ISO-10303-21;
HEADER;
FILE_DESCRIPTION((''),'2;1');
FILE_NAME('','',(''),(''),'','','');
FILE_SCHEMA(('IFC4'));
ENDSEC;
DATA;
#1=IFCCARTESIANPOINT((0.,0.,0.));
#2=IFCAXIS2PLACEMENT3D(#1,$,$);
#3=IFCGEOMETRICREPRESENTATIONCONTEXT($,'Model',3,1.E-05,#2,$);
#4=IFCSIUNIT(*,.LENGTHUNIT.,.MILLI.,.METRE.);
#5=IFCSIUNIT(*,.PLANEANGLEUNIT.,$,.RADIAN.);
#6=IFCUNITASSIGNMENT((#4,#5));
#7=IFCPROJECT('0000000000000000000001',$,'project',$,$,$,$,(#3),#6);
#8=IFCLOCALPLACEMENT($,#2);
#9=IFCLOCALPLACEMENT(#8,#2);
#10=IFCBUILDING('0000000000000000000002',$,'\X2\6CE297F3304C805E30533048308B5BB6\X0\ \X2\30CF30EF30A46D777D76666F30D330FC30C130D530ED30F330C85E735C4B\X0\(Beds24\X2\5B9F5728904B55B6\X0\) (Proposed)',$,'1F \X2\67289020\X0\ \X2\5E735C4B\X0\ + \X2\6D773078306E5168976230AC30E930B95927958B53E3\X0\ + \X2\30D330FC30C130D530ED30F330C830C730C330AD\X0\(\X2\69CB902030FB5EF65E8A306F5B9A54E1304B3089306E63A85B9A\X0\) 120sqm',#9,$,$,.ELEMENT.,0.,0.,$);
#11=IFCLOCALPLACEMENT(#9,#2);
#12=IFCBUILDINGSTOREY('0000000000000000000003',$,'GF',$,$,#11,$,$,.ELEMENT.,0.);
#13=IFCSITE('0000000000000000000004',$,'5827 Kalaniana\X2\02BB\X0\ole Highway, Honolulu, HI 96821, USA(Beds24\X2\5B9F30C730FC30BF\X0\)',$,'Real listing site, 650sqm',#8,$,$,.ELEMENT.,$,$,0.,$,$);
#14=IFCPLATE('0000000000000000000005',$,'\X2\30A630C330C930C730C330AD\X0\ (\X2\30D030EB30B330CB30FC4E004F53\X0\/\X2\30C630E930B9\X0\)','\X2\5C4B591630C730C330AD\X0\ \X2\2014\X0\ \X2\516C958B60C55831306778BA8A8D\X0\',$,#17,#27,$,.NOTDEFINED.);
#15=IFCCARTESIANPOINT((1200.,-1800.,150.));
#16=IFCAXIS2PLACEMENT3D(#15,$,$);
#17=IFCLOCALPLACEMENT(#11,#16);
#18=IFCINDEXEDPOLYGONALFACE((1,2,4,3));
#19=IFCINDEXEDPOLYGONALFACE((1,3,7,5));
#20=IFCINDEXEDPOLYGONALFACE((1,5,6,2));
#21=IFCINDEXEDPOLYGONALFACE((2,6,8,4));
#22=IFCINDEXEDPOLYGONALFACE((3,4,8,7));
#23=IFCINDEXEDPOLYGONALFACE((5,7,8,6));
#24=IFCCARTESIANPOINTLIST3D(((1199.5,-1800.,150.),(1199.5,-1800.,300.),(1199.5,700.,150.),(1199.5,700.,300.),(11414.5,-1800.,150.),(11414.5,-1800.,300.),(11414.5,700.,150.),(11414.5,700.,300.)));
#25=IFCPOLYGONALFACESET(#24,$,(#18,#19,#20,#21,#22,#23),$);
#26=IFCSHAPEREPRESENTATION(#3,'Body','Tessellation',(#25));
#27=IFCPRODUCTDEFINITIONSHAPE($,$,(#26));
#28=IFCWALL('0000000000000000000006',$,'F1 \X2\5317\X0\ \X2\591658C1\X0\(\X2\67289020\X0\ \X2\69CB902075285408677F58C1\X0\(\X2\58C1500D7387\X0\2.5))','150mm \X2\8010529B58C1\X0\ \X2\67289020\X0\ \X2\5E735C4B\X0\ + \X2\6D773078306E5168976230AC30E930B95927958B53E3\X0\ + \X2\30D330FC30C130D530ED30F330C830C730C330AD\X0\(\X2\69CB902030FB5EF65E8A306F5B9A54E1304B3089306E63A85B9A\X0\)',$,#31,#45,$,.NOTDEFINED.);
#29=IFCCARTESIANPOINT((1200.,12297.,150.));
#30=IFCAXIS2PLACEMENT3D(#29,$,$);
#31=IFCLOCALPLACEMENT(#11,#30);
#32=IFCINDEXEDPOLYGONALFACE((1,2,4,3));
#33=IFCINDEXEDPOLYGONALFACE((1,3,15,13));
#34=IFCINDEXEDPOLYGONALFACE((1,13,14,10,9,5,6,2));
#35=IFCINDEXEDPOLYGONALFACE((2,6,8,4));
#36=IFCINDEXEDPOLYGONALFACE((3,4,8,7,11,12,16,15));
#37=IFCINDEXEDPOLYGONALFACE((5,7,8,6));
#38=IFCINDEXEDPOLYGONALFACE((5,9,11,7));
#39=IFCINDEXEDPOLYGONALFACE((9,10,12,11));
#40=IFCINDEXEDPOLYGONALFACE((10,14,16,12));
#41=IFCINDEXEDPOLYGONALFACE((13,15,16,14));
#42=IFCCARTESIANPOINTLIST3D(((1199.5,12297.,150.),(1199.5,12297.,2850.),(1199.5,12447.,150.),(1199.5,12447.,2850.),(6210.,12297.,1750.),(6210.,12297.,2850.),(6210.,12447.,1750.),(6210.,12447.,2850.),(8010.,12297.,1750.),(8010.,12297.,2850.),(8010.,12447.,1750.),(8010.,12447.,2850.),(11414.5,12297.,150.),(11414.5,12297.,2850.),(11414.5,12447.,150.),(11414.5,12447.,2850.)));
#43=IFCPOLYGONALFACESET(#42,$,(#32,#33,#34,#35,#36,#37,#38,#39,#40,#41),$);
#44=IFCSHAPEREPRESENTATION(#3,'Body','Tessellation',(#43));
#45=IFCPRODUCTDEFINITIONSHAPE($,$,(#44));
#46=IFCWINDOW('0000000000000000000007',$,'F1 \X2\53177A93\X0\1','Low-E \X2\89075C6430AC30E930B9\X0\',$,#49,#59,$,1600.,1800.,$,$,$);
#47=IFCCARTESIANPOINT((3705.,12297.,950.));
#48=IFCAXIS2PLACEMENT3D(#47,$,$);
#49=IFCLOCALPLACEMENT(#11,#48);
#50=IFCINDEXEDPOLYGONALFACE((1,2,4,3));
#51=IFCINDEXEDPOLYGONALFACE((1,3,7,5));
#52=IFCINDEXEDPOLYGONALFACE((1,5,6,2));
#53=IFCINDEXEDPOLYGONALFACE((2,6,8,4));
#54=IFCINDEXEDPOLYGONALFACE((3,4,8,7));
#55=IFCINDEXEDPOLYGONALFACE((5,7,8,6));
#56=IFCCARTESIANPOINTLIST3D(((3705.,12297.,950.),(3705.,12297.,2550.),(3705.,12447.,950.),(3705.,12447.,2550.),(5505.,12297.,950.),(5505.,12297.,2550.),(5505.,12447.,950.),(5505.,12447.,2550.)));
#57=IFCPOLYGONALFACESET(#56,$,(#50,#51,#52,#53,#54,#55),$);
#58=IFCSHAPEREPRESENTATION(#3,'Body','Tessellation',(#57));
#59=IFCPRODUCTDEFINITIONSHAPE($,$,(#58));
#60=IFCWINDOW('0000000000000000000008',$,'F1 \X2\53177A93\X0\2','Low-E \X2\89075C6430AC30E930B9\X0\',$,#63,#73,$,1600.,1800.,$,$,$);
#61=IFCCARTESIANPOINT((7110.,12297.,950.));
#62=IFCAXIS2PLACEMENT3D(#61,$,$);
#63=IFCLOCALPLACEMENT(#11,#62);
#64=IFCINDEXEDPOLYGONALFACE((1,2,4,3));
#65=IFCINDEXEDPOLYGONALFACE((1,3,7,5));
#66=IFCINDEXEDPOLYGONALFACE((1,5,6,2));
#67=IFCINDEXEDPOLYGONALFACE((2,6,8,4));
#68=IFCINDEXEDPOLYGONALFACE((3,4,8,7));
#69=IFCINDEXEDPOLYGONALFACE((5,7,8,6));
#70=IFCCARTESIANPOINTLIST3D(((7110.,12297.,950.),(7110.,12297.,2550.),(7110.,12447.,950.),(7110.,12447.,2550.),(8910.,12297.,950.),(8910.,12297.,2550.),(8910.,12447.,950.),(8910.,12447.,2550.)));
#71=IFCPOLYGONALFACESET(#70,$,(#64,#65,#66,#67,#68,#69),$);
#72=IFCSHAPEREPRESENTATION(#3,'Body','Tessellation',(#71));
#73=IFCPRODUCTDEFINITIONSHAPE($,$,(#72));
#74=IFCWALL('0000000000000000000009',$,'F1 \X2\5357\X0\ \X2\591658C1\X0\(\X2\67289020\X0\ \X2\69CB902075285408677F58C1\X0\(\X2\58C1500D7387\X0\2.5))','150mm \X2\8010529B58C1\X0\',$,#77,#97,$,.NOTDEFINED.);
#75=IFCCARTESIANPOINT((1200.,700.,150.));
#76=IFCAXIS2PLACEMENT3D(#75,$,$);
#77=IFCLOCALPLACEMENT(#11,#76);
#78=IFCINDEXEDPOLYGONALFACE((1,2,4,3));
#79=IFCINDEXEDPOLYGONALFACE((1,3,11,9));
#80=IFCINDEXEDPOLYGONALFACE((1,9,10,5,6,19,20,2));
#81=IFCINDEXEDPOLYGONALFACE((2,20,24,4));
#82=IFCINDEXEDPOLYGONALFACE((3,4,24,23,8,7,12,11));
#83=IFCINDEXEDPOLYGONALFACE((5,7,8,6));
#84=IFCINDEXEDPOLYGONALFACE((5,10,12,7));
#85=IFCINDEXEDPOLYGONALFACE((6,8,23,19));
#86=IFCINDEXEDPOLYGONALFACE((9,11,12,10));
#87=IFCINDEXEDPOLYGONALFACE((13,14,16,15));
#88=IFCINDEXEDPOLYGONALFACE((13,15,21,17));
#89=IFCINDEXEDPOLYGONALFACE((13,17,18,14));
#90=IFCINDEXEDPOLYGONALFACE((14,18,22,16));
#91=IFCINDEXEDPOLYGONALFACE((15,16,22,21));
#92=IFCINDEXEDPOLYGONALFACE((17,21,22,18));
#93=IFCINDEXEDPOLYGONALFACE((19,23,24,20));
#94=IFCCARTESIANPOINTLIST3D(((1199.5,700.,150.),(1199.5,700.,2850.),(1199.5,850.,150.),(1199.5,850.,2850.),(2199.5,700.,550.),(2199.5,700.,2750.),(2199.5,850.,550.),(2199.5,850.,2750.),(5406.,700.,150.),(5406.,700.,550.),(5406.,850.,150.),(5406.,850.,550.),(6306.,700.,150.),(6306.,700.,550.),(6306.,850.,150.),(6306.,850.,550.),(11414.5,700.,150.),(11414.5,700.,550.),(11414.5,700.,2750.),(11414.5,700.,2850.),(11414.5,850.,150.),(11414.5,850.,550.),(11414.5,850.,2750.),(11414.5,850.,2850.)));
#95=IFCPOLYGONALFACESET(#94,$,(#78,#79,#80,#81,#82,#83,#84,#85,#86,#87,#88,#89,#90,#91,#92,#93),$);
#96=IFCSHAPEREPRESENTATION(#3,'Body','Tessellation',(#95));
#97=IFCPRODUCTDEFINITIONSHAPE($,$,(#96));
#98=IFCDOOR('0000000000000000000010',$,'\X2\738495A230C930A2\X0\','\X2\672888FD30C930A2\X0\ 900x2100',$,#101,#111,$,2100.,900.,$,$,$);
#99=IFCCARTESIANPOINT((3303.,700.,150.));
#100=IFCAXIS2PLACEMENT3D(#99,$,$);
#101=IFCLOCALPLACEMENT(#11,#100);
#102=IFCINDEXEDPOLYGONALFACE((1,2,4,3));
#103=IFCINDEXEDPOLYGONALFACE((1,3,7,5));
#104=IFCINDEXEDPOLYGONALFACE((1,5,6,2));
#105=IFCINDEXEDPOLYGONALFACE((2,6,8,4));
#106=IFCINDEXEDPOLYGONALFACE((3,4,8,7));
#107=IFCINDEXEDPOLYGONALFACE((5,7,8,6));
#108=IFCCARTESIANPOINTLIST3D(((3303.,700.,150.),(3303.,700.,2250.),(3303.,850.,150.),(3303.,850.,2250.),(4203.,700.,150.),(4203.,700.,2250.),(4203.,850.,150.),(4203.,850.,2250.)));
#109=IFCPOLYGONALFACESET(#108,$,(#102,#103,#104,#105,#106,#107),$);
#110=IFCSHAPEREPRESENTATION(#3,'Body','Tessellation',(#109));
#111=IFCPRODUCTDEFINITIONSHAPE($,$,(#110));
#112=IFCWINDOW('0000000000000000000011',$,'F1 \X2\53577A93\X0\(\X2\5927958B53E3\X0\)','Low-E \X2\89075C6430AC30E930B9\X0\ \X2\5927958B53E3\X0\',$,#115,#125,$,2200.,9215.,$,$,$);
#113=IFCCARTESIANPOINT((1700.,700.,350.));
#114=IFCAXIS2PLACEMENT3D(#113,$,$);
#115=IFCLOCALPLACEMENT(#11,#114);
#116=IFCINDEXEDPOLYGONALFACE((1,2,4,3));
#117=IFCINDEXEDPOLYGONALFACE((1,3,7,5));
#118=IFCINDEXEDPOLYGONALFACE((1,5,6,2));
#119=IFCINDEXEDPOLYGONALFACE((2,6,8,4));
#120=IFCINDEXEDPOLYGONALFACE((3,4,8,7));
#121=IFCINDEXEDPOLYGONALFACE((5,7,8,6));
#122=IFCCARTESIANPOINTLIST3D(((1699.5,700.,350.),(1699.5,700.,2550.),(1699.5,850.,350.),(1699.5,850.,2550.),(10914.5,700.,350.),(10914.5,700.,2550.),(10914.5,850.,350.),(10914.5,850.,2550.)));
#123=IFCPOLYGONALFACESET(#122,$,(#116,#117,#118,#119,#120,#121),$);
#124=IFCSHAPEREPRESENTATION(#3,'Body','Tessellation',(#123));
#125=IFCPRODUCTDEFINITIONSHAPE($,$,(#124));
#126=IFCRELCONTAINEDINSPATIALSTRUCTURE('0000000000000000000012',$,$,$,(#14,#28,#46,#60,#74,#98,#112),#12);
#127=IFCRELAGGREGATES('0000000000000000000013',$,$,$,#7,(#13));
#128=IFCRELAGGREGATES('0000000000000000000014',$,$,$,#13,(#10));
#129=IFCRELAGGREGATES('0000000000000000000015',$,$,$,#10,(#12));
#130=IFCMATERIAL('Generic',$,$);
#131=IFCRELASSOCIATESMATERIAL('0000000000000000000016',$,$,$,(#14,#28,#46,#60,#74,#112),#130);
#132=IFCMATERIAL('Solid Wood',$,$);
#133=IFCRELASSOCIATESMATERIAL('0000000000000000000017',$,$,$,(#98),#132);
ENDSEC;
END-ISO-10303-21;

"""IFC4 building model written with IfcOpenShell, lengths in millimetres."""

from ifc_helpers import new_model, si_unit, frame, frame_2d, origin, place, context, project, spatial, rectangle, extrude, material, element, fill, save


model = new_model("IFC4")

# Units and contexts
model_context = context("Model", 3, precision=1e-05, world=origin())
ifc_project = project(units=[si_unit("LENGTHUNIT", "METRE", prefix="MILLI"), si_unit("PLANEANGLEUNIT", "RADIAN")], contexts=[model_context])

# Site, building, storey
site_placement = place(None, origin())
site = spatial("IfcSite", under=ifc_project, at=site_placement, Name="5827 Kalanianaʻole Highway, Honolulu, HI 96821, USA(Beds24実データ)", ObjectType="Real listing site, 650sqm", CompositionType="ELEMENT", RefElevation=0.0)
building_placement = place(site_placement, origin())
building = spatial("IfcBuilding", under=site, at=building_placement, Name="波音が聞こえる家 ハワイ海絶景ビーチフロント平屋(Beds24実在運営) (Proposed)", ObjectType="1F 木造 平屋 + 海への全面ガラス大開口 + ビーチフロントデッキ(構造・延床は定員からの推定) 120sqm", CompositionType="ELEMENT", ElevationOfRefHeight=0.0, ElevationOfTerrain=0.0)
storey_placement = place(building_placement, origin())
storey = spatial("IfcBuildingStorey", under=building, at=storey_placement, Name="GF", CompositionType="ELEMENT", Elevation=0.0)

# Shared definitions
ifc_material_1 = material(Name="Generic")

# Plate
plate_placement = place(storey_placement, frame((1200.0, -1800.0, 150.0)))
element("IfcPlate", 1, at=plate_placement, inside=storey, material=ifc_material_1, Name="ウッドデッキ (バルコニー一体/テラス)", Description="屋外デッキ — 公開情報で確認", PredefinedType="NOTDEFINED", context=model_context, shape_type="SweptSolid", body=[
    extrude(rectangle(XDim=10215.0, YDim=2500.0, at=frame_2d((5107.0, 1250.0))), frame((1200.0, -1800.0, 150.0)), (0.0, 0.0, 1.0), 150.0),
])

# Wall, openings, windows
wall_1_placement = place(storey_placement, frame((1200.0, 12297.0, 150.0)))
wall_1 = element("IfcWall", 2, at=wall_1_placement, inside=storey, material=ifc_material_1, Name="F1 北 外壁(木造 構造用合板壁(壁倍率2.5))", Description="150mm 耐力壁 木造 平屋 + 海への全面ガラス大開口 + ビーチフロントデッキ(構造・延床は定員からの推定)", PredefinedType="NOTDEFINED", context=model_context, shape_type="SweptSolid", body=[
    extrude(rectangle(XDim=10215.0, YDim=150.0, at=frame_2d((5107.0, 75.0))), frame((1200.0, 12297.0, 150.0)), (0.0, 0.0, 1.0), 2700.0),
])
opening_1_placement = place(storey_placement, frame((3705.0, 12297.0, 950.0)))
opening_1 = element("IfcOpeningElement", 3, at=opening_1_placement, cuts=wall_1, PredefinedType="NOTDEFINED", context=model_context, shape_type="SweptSolid", body=[
    extrude(rectangle(XDim=1800.0, YDim=150.0, at=frame_2d((900.0, 75.0))), frame((3705.0, 12297.0, 950.0)), (0.0, 0.0, 1.0), 1600.0),
])
opening_2_placement = place(storey_placement, frame((7110.0, 12297.0, 950.0)))
opening_2 = element("IfcOpeningElement", 4, at=opening_2_placement, cuts=wall_1, PredefinedType="NOTDEFINED", context=model_context, shape_type="SweptSolid", body=[
    extrude(rectangle(XDim=1800.0, YDim=150.0, at=frame_2d((900.0, 75.0))), frame((7110.0, 12297.0, 950.0)), (0.0, 0.0, 1.0), 1600.0),
])
window_1_placement = place(storey_placement, frame((3705.0, 12297.0, 950.0)))
window_1 = element("IfcWindow", 5, at=window_1_placement, inside=storey, material=ifc_material_1, Name="F1 北窓1", Description="Low-E 複層ガラス", OverallHeight=1600.0, OverallWidth=1800.0, context=model_context, shape_type="SweptSolid", body=[
    extrude(rectangle(XDim=1800.0, YDim=150.0, at=frame_2d((900.0, 75.0))), frame((3705.0, 12297.0, 950.0)), (0.0, 0.0, 1.0), 1600.0),
])
fill(opening_1, window_1)
window_2_placement = place(storey_placement, frame((7110.0, 12297.0, 950.0)))
window_2 = element("IfcWindow", 6, at=window_2_placement, inside=storey, material=ifc_material_1, Name="F1 北窓2", Description="Low-E 複層ガラス", OverallHeight=1600.0, OverallWidth=1800.0, context=model_context, shape_type="SweptSolid", body=[
    extrude(rectangle(XDim=1800.0, YDim=150.0, at=frame_2d((900.0, 75.0))), frame((7110.0, 12297.0, 950.0)), (0.0, 0.0, 1.0), 1600.0),
])
fill(opening_2, window_2)

# Wall, openings, door, window
wall_2_placement = place(storey_placement, frame((1200.0, 700.0, 150.0)))
wall_2 = element("IfcWall", 7, at=wall_2_placement, inside=storey, material=ifc_material_1, Name="F1 南 外壁(木造 構造用合板壁(壁倍率2.5))", Description="150mm 耐力壁", PredefinedType="NOTDEFINED", context=model_context, shape_type="SweptSolid", body=[
    extrude(rectangle(XDim=10215.0, YDim=150.0, at=frame_2d((5107.0, 75.0))), frame((1200.0, 700.0, 150.0)), (0.0, 0.0, 1.0), 2700.0),
])
opening_3_placement = place(storey_placement, frame((3303.0, 700.0, 150.0)))
opening_3 = element("IfcOpeningElement", 8, at=opening_3_placement, cuts=wall_2, PredefinedType="NOTDEFINED", context=model_context, shape_type="SweptSolid", body=[
    extrude(rectangle(XDim=900.0, YDim=150.0, at=frame_2d((450.0, 75.0))), frame((3303.0, 700.0, 150.0)), (0.0, 0.0, 1.0), 2100.0),
])
opening_4_placement = place(storey_placement, frame((1700.0, 700.0, 350.0)))
opening_4 = element("IfcOpeningElement", 9, at=opening_4_placement, cuts=wall_2, PredefinedType="NOTDEFINED", context=model_context, shape_type="SweptSolid", body=[
    extrude(rectangle(XDim=9215.0, YDim=150.0, at=frame_2d((4607.0, 75.0))), frame((1700.0, 700.0, 350.0)), (0.0, 0.0, 1.0), 2200.0),
])
ifc_material_2 = material(Name="Solid Wood")
door_placement = place(storey_placement, frame((3303.0, 700.0, 150.0)))
door = element("IfcDoor", 10, at=door_placement, inside=storey, material=ifc_material_2, Name="玄関ドア", Description="木製ドア 900x2100", OverallHeight=2100.0, OverallWidth=900.0, context=model_context, shape_type="SweptSolid", body=[
    extrude(rectangle(XDim=900.0, YDim=150.0, at=frame_2d((450.0, 75.0))), frame((3303.0, 700.0, 150.0)), (0.0, 0.0, 1.0), 2100.0),
])
fill(opening_3, door)
window_3_placement = place(storey_placement, frame((1700.0, 700.0, 350.0)))
window_3 = element("IfcWindow", 11, at=window_3_placement, inside=storey, material=ifc_material_1, Name="F1 南窓(大開口)", Description="Low-E 複層ガラス 大開口", OverallHeight=2200.0, OverallWidth=9215.0, context=model_context, shape_type="SweptSolid", body=[
    extrude(rectangle(XDim=9215.0, YDim=150.0, at=frame_2d((4607.0, 75.0))), frame((1700.0, 700.0, 350.0)), (0.0, 0.0, 1.0), 2200.0),
])
fill(opening_4, window_3)

save(model, "model.ifc")
